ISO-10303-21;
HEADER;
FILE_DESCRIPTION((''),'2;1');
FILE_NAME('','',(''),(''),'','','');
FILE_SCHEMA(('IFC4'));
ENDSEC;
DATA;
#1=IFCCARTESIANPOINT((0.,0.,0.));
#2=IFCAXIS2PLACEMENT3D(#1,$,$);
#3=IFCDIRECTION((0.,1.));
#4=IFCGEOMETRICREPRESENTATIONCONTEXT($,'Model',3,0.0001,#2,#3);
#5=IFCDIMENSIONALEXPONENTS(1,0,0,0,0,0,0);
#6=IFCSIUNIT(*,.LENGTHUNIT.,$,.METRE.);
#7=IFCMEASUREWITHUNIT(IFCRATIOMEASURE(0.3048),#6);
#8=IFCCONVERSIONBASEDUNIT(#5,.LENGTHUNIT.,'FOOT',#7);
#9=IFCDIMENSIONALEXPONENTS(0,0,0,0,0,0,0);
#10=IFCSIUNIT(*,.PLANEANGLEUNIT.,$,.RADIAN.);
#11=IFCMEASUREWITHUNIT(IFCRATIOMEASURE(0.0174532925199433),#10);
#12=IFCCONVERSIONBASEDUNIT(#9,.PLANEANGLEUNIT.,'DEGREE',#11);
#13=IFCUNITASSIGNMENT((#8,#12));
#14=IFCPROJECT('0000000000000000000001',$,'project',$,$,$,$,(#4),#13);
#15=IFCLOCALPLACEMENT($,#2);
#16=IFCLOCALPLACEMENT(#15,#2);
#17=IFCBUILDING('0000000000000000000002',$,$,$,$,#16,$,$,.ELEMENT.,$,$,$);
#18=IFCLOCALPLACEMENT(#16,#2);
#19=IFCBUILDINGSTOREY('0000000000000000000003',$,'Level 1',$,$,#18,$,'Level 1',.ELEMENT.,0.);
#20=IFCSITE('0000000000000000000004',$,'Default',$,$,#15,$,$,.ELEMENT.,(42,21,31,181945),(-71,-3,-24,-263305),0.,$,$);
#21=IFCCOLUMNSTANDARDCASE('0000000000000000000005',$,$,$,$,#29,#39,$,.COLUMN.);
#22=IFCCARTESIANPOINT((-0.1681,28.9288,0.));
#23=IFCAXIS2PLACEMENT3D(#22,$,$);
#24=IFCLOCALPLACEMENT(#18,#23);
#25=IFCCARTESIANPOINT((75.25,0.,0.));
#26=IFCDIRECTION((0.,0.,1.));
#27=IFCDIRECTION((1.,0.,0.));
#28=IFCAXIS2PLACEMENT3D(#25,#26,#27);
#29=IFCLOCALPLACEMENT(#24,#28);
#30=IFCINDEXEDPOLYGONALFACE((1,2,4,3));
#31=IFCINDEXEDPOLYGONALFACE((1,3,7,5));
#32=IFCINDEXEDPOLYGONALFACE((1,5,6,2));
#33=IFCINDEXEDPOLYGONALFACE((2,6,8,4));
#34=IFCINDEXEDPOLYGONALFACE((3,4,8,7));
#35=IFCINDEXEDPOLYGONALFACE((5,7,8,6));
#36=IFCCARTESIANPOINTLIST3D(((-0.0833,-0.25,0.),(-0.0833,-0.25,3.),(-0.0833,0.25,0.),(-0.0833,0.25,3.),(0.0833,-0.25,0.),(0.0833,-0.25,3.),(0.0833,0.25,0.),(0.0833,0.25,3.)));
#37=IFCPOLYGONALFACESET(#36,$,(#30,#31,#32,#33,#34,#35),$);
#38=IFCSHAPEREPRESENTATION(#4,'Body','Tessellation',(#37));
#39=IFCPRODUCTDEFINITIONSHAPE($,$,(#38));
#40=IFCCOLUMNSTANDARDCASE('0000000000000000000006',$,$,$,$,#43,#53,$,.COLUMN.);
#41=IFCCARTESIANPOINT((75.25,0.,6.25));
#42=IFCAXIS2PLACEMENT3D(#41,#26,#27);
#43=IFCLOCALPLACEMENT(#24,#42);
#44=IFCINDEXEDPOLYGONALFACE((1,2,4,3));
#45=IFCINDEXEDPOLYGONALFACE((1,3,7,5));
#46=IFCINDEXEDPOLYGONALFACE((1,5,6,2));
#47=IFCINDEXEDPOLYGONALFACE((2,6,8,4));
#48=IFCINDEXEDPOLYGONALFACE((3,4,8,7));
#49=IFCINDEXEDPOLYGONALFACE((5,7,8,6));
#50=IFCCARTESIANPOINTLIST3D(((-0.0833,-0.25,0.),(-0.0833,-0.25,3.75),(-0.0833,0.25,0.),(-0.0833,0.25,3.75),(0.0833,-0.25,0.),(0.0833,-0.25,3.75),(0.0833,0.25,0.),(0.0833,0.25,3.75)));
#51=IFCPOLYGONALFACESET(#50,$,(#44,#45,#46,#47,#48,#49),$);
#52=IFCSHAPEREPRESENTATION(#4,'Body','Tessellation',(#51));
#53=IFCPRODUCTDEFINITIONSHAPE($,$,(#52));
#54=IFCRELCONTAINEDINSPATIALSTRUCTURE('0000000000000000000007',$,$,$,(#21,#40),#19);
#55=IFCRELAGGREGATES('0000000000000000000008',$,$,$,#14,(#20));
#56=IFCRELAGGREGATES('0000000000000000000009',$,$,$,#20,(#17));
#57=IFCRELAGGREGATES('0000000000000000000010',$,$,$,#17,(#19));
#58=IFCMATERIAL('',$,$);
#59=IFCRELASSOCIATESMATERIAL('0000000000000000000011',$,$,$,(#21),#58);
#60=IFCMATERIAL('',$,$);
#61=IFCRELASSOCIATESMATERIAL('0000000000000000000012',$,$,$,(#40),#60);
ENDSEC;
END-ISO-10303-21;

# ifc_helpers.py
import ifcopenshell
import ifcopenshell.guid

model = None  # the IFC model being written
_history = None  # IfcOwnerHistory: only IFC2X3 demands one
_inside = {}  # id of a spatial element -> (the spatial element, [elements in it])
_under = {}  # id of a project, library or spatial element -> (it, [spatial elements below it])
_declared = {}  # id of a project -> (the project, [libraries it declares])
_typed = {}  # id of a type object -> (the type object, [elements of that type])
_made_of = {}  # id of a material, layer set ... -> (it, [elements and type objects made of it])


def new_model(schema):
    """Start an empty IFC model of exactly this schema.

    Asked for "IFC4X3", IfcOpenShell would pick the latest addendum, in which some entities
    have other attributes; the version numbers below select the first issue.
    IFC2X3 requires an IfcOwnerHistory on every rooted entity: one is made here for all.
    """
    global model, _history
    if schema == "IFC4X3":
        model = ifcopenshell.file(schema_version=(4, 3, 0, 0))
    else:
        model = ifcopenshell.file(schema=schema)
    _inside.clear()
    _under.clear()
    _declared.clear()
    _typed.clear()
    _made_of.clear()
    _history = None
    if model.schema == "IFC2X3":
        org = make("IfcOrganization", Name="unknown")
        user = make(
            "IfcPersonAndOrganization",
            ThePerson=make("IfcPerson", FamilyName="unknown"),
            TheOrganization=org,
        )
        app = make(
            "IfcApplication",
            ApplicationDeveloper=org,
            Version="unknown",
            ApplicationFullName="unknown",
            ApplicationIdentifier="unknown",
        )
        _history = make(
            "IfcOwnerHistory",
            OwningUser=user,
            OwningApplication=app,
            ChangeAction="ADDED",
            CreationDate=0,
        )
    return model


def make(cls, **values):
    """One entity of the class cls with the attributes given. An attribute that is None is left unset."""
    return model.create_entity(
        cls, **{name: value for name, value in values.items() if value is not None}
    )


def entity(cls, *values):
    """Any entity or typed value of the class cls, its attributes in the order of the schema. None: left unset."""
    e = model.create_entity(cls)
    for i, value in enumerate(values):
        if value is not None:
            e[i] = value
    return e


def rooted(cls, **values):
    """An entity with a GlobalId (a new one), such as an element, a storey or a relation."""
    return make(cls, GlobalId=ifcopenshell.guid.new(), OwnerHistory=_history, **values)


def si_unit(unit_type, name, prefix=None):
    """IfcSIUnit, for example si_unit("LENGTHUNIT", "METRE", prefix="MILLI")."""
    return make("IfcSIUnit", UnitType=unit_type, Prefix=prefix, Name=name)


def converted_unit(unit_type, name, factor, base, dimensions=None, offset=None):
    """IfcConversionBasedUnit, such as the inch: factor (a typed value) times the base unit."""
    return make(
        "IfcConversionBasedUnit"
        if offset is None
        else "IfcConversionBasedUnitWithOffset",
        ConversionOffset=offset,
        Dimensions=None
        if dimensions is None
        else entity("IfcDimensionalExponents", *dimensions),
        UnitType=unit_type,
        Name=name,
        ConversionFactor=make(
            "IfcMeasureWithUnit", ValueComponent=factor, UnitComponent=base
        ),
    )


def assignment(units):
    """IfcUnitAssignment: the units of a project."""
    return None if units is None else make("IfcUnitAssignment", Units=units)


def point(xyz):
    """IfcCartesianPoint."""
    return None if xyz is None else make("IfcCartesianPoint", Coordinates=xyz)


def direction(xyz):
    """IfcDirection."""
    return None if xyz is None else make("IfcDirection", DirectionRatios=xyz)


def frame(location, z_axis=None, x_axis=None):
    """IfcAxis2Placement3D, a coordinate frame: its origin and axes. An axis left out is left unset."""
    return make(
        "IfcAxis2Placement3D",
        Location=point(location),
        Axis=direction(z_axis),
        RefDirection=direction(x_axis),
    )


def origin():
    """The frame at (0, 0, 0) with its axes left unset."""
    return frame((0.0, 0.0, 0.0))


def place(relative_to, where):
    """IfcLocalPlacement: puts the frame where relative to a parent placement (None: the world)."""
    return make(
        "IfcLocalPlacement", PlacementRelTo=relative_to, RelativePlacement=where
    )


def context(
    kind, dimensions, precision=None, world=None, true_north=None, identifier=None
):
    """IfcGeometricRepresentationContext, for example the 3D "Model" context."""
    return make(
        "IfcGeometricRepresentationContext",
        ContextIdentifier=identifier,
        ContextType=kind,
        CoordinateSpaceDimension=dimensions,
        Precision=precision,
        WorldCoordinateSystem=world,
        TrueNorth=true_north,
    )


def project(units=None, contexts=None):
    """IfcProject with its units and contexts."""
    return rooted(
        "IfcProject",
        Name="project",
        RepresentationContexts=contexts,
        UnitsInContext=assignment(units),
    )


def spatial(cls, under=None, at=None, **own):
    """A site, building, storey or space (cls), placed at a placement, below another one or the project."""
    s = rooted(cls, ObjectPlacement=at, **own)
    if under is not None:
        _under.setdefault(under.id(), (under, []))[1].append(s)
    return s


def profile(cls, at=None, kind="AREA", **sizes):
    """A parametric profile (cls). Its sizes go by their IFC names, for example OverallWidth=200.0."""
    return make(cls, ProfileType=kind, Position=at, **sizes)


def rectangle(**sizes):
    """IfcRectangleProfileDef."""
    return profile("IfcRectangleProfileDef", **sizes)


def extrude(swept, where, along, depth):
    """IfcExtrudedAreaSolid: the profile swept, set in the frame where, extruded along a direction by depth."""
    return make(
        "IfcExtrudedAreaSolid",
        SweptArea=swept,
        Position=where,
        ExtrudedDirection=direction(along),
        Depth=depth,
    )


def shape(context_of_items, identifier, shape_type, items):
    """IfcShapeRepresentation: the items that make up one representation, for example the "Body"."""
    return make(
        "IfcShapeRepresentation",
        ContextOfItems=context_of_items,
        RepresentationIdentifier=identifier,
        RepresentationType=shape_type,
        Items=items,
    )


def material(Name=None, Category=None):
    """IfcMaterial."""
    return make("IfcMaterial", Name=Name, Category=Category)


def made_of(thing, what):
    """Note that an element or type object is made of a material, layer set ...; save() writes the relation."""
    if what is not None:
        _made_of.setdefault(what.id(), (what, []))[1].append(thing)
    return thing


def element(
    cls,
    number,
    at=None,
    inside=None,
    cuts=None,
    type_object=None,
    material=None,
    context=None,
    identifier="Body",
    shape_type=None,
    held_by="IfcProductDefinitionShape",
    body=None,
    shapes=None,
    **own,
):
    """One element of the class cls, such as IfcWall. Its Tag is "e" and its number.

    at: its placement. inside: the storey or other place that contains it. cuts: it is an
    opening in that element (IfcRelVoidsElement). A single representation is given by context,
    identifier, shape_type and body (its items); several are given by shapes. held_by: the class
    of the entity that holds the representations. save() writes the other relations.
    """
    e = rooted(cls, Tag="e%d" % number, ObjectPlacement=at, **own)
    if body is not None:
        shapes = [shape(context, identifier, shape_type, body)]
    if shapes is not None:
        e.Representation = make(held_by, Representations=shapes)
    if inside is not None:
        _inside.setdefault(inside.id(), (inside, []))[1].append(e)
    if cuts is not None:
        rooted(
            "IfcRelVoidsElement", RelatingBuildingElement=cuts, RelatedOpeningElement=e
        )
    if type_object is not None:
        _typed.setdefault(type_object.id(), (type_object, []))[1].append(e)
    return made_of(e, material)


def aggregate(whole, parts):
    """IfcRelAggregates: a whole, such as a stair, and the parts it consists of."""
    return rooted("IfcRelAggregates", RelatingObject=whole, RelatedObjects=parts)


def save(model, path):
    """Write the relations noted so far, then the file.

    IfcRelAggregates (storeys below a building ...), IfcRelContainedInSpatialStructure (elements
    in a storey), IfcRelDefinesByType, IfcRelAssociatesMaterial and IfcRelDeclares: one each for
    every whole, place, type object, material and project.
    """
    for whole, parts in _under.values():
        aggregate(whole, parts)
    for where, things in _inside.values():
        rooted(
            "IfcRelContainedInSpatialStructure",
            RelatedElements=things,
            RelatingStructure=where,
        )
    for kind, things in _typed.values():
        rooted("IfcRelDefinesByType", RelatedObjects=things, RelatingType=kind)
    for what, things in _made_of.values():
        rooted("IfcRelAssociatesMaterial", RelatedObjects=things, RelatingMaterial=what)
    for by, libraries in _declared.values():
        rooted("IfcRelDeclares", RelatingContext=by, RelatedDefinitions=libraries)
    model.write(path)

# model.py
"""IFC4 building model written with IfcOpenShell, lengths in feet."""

from ifc_helpers import new_model, entity, si_unit, converted_unit, direction, frame, origin, place, context, project, spatial, rectangle, extrude, material, element, save


model = new_model("IFC4")

# Units and contexts
model_context = context("Model", 3, precision=0.0001, world=origin(), true_north=direction((0.0, 1.0)))
ifc_project = project(units=[converted_unit("LENGTHUNIT", "FOOT", entity("IfcRatioMeasure", 0.3048), si_unit("LENGTHUNIT", "METRE"), dimensions=[1, 0, 0, 0, 0, 0, 0]), converted_unit("PLANEANGLEUNIT", "DEGREE", entity("IfcRatioMeasure", 0.0174532925199433), si_unit("PLANEANGLEUNIT", "RADIAN"), dimensions=[0, 0, 0, 0, 0, 0, 0])], contexts=[model_context])

# Site, building, storey
site_placement = place(None, origin())
site = spatial("IfcSite", under=ifc_project, at=site_placement, Name="Default", CompositionType="ELEMENT", RefLatitude=(42, 21, 31, 181945), RefLongitude=(-71, -3, -24, -263305), RefElevation=0.0)
building_placement = place(site_placement, origin())
building = spatial("IfcBuilding", under=site, at=building_placement, CompositionType="ELEMENT")
storey_placement = place(building_placement, origin())
storey = spatial("IfcBuildingStorey", under=building, at=storey_placement, Name="Level 1", LongName="Level 1", CompositionType="ELEMENT", Elevation=0.0)

# Columns
ifc_material_1 = material(Name="")
placement = place(storey_placement, frame((-0.1681, 28.9288, 0.0)))
for number, where, z_axis, x_axis in (
    (1, (75.25, 0.0, 0.0), (0.0, 0.0, 1.0), (1.0, 0.0, 0.0)),
):
    element("IfcColumnStandardCase", number, at=place(placement, frame(where, z_axis=z_axis, x_axis=x_axis)), inside=storey, material=ifc_material_1, PredefinedType="COLUMN", context=model_context, shape_type="SweptSolid", body=[
        extrude(rectangle(XDim=0.1667, YDim=0.5), origin(), (0.0, 0.0, 1.0), 3.0),
    ])
ifc_material_2 = material(Name="")
for number, where, z_axis, x_axis in (
    (2, (75.25, 0.0, 6.25), (0.0, 0.0, 1.0), (1.0, 0.0, 0.0)),
):
    element("IfcColumnStandardCase", number, at=place(placement, frame(where, z_axis=z_axis, x_axis=x_axis)), inside=storey, material=ifc_material_2, PredefinedType="COLUMN", context=model_context, shape_type="SweptSolid", body=[
        extrude(rectangle(XDim=0.1667, YDim=0.5), origin(), (0.0, 0.0, 1.0), 3.75),
    ])

save(model, "model.ifc")
